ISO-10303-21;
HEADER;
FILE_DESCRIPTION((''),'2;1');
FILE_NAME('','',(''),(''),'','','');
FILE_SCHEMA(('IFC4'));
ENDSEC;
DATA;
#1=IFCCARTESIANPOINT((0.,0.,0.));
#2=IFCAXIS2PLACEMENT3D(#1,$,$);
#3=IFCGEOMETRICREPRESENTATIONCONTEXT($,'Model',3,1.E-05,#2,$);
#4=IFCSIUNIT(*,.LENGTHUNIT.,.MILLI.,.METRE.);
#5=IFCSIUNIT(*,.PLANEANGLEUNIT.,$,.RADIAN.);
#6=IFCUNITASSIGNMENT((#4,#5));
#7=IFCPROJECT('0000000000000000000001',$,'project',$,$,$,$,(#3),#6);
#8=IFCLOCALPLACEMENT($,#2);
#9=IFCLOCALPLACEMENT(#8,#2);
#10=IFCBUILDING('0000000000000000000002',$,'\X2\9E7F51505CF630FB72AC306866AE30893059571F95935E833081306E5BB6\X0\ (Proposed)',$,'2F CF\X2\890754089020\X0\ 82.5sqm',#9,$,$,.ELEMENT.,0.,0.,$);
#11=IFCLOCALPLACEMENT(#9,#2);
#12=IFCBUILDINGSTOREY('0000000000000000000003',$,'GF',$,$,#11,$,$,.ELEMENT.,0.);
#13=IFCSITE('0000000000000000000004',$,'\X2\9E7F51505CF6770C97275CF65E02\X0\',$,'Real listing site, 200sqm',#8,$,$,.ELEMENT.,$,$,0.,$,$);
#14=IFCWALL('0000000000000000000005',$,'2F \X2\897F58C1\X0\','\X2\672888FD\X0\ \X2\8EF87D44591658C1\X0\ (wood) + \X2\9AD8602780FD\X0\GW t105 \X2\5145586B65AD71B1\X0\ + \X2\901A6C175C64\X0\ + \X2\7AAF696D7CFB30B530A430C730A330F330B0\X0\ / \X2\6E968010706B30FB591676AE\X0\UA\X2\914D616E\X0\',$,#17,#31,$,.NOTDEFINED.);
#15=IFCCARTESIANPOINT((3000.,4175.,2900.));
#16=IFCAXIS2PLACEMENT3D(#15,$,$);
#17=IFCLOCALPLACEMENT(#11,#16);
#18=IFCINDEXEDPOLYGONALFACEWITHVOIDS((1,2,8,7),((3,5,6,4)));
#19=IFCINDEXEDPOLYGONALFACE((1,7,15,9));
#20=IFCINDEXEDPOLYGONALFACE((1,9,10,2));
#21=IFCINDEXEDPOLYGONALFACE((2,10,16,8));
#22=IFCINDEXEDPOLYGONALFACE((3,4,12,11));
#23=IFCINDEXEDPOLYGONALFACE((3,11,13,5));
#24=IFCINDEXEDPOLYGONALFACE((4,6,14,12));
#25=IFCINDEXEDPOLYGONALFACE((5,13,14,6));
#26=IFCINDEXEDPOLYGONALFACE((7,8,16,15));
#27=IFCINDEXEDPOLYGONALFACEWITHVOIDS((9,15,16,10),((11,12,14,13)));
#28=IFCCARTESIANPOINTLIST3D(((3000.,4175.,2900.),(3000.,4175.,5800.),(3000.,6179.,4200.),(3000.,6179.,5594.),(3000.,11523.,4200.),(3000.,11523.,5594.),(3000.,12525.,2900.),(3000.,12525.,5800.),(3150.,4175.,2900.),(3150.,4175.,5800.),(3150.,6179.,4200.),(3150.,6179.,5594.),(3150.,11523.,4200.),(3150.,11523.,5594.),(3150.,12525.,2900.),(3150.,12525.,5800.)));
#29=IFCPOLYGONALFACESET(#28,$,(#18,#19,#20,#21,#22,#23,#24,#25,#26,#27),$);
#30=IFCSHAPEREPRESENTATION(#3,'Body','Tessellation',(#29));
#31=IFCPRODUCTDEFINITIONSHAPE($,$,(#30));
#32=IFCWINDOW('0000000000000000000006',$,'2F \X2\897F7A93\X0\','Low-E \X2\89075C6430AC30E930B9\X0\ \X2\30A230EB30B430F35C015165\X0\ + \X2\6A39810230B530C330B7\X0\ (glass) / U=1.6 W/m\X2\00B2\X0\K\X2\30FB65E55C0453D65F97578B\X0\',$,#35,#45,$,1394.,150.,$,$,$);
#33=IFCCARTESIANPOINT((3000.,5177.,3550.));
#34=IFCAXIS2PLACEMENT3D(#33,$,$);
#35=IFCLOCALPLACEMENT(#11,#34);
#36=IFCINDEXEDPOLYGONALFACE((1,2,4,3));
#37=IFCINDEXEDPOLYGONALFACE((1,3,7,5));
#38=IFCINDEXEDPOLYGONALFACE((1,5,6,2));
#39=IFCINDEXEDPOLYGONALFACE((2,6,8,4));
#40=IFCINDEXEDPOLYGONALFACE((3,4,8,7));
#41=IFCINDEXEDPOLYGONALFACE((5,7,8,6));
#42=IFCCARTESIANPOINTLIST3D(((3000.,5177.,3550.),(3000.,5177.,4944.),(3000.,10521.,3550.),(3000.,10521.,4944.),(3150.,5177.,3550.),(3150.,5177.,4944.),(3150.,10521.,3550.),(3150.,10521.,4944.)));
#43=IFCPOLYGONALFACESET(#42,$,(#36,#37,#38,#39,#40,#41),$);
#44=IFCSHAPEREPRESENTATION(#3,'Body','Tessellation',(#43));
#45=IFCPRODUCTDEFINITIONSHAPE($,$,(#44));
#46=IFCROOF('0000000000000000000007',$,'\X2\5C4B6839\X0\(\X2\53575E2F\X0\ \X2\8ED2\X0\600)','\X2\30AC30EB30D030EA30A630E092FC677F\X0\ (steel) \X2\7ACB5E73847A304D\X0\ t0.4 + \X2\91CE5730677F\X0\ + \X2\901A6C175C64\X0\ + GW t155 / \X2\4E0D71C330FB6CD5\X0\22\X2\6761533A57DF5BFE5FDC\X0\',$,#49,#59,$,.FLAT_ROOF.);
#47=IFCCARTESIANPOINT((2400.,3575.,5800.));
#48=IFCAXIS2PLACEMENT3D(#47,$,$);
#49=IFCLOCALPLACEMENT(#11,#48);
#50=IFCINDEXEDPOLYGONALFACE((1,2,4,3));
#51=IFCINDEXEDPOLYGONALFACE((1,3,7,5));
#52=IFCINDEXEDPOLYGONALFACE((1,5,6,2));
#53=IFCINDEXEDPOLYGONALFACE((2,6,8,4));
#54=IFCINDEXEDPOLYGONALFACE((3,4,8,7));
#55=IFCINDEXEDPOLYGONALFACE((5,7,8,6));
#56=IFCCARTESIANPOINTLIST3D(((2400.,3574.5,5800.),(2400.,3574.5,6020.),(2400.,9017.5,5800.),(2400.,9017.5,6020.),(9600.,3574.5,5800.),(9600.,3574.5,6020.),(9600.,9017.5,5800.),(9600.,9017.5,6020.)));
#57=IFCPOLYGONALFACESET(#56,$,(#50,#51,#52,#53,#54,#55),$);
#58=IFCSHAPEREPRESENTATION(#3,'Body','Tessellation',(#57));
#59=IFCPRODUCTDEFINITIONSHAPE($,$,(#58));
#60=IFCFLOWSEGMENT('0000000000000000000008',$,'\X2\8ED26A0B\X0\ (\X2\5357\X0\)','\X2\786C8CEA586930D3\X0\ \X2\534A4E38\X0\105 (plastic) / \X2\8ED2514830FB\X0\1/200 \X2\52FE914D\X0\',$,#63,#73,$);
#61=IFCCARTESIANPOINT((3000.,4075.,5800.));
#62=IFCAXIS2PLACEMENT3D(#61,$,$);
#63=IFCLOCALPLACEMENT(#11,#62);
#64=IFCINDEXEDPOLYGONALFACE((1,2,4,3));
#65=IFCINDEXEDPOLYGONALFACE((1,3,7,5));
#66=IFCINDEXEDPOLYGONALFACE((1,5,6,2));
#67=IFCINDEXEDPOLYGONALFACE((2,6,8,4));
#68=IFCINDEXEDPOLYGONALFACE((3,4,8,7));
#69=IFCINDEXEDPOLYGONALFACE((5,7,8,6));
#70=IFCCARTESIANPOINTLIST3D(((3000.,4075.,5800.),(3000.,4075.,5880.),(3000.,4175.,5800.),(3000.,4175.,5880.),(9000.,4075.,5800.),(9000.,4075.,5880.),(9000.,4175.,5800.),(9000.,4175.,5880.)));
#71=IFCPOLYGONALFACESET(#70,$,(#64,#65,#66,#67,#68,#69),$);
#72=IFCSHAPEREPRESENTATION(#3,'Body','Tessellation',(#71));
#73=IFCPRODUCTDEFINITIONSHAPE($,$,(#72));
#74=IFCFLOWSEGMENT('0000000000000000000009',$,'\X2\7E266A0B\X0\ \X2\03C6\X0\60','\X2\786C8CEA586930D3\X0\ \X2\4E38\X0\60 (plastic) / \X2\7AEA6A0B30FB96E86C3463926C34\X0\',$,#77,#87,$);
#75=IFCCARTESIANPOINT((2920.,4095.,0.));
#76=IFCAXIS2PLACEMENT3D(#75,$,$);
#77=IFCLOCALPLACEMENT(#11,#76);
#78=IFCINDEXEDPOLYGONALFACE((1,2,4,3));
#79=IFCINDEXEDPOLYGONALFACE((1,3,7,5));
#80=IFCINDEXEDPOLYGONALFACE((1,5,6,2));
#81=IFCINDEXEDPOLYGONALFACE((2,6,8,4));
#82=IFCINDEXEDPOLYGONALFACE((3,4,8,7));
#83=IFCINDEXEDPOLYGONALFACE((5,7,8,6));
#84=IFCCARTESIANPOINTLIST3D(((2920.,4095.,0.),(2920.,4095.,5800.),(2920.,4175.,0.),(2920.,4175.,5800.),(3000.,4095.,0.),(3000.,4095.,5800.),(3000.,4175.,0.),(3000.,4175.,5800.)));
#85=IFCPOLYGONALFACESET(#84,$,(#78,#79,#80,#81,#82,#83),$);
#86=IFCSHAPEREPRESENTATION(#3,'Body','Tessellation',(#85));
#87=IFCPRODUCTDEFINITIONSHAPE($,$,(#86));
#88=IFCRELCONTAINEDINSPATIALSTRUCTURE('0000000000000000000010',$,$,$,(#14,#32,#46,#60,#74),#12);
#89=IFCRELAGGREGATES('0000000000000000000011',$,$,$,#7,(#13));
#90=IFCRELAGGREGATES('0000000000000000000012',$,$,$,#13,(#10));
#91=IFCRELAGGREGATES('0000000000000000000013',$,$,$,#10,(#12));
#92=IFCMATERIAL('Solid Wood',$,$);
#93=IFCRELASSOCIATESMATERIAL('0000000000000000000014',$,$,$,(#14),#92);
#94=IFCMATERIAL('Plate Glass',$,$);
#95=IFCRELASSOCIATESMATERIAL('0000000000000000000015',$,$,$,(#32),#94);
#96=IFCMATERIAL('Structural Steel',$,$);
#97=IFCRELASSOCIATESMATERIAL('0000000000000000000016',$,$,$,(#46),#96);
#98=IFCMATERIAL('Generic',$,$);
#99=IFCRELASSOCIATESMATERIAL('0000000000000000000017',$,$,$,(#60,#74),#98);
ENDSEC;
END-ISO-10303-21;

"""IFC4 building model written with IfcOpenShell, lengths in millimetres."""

from ifc_helpers import new_model, si_unit, frame, frame_2d, origin, place, context, project, spatial, rectangle, extrude, material, element, fill, save


model = new_model("IFC4")

# Units and contexts
model_context = context("Model", 3, precision=1e-05, world=origin())
ifc_project = project(units=[si_unit("LENGTHUNIT", "METRE", prefix="MILLI"), si_unit("PLANEANGLEUNIT", "RADIAN")], contexts=[model_context])

# Site, building, storey
site_placement = place(None, origin())
site = spatial("IfcSite", under=ifc_project, at=site_placement, Name="鹿児島県霧島市", ObjectType="Real listing site, 200sqm", CompositionType="ELEMENT", RefElevation=0.0)
building_placement = place(site_placement, origin())
building = spatial("IfcBuilding", under=site, at=building_placement, Name="鹿児島・犬と暮らす土間広めの家 (Proposed)", ObjectType="2F CF複合造 82.5sqm", CompositionType="ELEMENT", ElevationOfRefHeight=0.0, ElevationOfTerrain=0.0)
storey_placement = place(building_placement, origin())
storey = spatial("IfcBuildingStorey", under=building, at=storey_placement, Name="GF", CompositionType="ELEMENT", Elevation=0.0)

# Shared definitions
ifc_material_1 = material(Name="Solid Wood")

# Shared definitions
ifc_material_2 = material(Name="Plate Glass")

# Wall, opening, window
wall_1_placement = place(storey_placement, frame((3000.0, 4175.0, 2900.0)))
wall_1 = element("IfcWall", 1, at=wall_1_placement, inside=storey, material=ifc_material_1, Name="2F 西壁", Description="木製 軸組外壁 (wood) + 高性能GW t105 充填断熱 + 通気層 + 窯業系サイディング / 準耐火・外皮UA配慮", PredefinedType="NOTDEFINED", context=model_context, shape_type="SweptSolid", body=[
    extrude(rectangle(XDim=150.0, YDim=8350.0, at=frame_2d((75.0, 4175.0))), frame((3000.0, 4175.0, 2900.0)), (0.0, 0.0, 1.0), 2900.0),
])
opening_1_placement = place(storey_placement, frame((3000.0, 5177.0, 3550.0)))
opening_1 = element("IfcOpeningElement", 2, at=opening_1_placement, cuts=wall_1, PredefinedType="NOTDEFINED", context=model_context, shape_type="SweptSolid", body=[
    extrude(rectangle(XDim=150.0, YDim=5344.0, at=frame_2d((75.0, 2672.0))), frame((3000.0, 5177.0, 3550.0)), (0.0, 0.0, 1.0), 1394.0),
])
window_1_placement = place(storey_placement, frame((3000.0, 5177.0, 3550.0)))
window_1 = element("IfcWindow", 3, at=window_1_placement, inside=storey, material=ifc_material_2, Name="2F 西窓", Description="Low-E 複層ガラス アルゴン封入 + 樹脂サッシ (glass) / U=1.6 W/m²K・日射取得型", OverallHeight=1394.0, OverallWidth=150.0, context=model_context, shape_type="SweptSolid", body=[
    extrude(rectangle(XDim=150.0, YDim=5344.0, at=frame_2d((75.0, 2672.0))), frame((3000.0, 5177.0, 3550.0)), (0.0, 0.0, 1.0), 1394.0),
])
fill(opening_1, window_1)

# Roof
ifc_material_3 = material(Name="Structural Steel")
for number, where, name in (
    (4, (2400.0, 3575.0, 5800.0), "屋根(南帯 軒600)"),
):
    element("IfcRoof", number, at=place(storey_placement, frame(where)), inside=storey, material=ifc_material_3, Name=name, Description="ガルバリウム鋼板 (steel) 立平葺き t0.4 + 野地板 + 通気層 + GW t155 / 不燃・法22条区域対応", PredefinedType="FLAT_ROOF", context=model_context, shape_type="SweptSolid", body=[
        extrude(rectangle(XDim=7200.0, YDim=5443.0, at=frame_2d((3600.0, 2721.0))), frame((2400.0, 3575.0, 5800.0)), (0.0, 0.0, 1.0), 220.0),
    ])

# Flow segments
ifc_material_4 = material(Name="Generic")
flow_segment_1_placement = place(storey_placement, frame((3000.0, 4075.0, 5800.0)))
element("IfcFlowSegment", 5, at=flow_segment_1_placement, inside=storey, material=ifc_material_4, Name="軒樋 (南)", Description="硬質塩ビ 半丸105 (plastic) / 軒先・1/200 勾配", context=model_context, shape_type="SweptSolid", body=[
    extrude(rectangle(XDim=6000.0, YDim=100.0, at=frame_2d((3000.0, 50.0))), frame((3000.0, 4075.0, 5800.0)), (0.0, 0.0, 1.0), 80.0),
])
flow_segment_2_placement = place(storey_placement, frame((2920.0, 4095.0, 0.0)))
element("IfcFlowSegment", 6, at=flow_segment_2_placement, inside=storey, material=ifc_material_4, Name="縦樋 φ60", Description="硬質塩ビ 丸60 (plastic) / 竪樋・雨水排水", context=model_context, shape_type="SweptSolid", body=[
    extrude(rectangle(XDim=80.0, YDim=80.0, at=frame_2d((40.0, 40.0))), frame((2920.0, 4095.0, 0.0)), (0.0, 0.0, 1.0), 5800.0),
])

save(model, "model.ifc")
